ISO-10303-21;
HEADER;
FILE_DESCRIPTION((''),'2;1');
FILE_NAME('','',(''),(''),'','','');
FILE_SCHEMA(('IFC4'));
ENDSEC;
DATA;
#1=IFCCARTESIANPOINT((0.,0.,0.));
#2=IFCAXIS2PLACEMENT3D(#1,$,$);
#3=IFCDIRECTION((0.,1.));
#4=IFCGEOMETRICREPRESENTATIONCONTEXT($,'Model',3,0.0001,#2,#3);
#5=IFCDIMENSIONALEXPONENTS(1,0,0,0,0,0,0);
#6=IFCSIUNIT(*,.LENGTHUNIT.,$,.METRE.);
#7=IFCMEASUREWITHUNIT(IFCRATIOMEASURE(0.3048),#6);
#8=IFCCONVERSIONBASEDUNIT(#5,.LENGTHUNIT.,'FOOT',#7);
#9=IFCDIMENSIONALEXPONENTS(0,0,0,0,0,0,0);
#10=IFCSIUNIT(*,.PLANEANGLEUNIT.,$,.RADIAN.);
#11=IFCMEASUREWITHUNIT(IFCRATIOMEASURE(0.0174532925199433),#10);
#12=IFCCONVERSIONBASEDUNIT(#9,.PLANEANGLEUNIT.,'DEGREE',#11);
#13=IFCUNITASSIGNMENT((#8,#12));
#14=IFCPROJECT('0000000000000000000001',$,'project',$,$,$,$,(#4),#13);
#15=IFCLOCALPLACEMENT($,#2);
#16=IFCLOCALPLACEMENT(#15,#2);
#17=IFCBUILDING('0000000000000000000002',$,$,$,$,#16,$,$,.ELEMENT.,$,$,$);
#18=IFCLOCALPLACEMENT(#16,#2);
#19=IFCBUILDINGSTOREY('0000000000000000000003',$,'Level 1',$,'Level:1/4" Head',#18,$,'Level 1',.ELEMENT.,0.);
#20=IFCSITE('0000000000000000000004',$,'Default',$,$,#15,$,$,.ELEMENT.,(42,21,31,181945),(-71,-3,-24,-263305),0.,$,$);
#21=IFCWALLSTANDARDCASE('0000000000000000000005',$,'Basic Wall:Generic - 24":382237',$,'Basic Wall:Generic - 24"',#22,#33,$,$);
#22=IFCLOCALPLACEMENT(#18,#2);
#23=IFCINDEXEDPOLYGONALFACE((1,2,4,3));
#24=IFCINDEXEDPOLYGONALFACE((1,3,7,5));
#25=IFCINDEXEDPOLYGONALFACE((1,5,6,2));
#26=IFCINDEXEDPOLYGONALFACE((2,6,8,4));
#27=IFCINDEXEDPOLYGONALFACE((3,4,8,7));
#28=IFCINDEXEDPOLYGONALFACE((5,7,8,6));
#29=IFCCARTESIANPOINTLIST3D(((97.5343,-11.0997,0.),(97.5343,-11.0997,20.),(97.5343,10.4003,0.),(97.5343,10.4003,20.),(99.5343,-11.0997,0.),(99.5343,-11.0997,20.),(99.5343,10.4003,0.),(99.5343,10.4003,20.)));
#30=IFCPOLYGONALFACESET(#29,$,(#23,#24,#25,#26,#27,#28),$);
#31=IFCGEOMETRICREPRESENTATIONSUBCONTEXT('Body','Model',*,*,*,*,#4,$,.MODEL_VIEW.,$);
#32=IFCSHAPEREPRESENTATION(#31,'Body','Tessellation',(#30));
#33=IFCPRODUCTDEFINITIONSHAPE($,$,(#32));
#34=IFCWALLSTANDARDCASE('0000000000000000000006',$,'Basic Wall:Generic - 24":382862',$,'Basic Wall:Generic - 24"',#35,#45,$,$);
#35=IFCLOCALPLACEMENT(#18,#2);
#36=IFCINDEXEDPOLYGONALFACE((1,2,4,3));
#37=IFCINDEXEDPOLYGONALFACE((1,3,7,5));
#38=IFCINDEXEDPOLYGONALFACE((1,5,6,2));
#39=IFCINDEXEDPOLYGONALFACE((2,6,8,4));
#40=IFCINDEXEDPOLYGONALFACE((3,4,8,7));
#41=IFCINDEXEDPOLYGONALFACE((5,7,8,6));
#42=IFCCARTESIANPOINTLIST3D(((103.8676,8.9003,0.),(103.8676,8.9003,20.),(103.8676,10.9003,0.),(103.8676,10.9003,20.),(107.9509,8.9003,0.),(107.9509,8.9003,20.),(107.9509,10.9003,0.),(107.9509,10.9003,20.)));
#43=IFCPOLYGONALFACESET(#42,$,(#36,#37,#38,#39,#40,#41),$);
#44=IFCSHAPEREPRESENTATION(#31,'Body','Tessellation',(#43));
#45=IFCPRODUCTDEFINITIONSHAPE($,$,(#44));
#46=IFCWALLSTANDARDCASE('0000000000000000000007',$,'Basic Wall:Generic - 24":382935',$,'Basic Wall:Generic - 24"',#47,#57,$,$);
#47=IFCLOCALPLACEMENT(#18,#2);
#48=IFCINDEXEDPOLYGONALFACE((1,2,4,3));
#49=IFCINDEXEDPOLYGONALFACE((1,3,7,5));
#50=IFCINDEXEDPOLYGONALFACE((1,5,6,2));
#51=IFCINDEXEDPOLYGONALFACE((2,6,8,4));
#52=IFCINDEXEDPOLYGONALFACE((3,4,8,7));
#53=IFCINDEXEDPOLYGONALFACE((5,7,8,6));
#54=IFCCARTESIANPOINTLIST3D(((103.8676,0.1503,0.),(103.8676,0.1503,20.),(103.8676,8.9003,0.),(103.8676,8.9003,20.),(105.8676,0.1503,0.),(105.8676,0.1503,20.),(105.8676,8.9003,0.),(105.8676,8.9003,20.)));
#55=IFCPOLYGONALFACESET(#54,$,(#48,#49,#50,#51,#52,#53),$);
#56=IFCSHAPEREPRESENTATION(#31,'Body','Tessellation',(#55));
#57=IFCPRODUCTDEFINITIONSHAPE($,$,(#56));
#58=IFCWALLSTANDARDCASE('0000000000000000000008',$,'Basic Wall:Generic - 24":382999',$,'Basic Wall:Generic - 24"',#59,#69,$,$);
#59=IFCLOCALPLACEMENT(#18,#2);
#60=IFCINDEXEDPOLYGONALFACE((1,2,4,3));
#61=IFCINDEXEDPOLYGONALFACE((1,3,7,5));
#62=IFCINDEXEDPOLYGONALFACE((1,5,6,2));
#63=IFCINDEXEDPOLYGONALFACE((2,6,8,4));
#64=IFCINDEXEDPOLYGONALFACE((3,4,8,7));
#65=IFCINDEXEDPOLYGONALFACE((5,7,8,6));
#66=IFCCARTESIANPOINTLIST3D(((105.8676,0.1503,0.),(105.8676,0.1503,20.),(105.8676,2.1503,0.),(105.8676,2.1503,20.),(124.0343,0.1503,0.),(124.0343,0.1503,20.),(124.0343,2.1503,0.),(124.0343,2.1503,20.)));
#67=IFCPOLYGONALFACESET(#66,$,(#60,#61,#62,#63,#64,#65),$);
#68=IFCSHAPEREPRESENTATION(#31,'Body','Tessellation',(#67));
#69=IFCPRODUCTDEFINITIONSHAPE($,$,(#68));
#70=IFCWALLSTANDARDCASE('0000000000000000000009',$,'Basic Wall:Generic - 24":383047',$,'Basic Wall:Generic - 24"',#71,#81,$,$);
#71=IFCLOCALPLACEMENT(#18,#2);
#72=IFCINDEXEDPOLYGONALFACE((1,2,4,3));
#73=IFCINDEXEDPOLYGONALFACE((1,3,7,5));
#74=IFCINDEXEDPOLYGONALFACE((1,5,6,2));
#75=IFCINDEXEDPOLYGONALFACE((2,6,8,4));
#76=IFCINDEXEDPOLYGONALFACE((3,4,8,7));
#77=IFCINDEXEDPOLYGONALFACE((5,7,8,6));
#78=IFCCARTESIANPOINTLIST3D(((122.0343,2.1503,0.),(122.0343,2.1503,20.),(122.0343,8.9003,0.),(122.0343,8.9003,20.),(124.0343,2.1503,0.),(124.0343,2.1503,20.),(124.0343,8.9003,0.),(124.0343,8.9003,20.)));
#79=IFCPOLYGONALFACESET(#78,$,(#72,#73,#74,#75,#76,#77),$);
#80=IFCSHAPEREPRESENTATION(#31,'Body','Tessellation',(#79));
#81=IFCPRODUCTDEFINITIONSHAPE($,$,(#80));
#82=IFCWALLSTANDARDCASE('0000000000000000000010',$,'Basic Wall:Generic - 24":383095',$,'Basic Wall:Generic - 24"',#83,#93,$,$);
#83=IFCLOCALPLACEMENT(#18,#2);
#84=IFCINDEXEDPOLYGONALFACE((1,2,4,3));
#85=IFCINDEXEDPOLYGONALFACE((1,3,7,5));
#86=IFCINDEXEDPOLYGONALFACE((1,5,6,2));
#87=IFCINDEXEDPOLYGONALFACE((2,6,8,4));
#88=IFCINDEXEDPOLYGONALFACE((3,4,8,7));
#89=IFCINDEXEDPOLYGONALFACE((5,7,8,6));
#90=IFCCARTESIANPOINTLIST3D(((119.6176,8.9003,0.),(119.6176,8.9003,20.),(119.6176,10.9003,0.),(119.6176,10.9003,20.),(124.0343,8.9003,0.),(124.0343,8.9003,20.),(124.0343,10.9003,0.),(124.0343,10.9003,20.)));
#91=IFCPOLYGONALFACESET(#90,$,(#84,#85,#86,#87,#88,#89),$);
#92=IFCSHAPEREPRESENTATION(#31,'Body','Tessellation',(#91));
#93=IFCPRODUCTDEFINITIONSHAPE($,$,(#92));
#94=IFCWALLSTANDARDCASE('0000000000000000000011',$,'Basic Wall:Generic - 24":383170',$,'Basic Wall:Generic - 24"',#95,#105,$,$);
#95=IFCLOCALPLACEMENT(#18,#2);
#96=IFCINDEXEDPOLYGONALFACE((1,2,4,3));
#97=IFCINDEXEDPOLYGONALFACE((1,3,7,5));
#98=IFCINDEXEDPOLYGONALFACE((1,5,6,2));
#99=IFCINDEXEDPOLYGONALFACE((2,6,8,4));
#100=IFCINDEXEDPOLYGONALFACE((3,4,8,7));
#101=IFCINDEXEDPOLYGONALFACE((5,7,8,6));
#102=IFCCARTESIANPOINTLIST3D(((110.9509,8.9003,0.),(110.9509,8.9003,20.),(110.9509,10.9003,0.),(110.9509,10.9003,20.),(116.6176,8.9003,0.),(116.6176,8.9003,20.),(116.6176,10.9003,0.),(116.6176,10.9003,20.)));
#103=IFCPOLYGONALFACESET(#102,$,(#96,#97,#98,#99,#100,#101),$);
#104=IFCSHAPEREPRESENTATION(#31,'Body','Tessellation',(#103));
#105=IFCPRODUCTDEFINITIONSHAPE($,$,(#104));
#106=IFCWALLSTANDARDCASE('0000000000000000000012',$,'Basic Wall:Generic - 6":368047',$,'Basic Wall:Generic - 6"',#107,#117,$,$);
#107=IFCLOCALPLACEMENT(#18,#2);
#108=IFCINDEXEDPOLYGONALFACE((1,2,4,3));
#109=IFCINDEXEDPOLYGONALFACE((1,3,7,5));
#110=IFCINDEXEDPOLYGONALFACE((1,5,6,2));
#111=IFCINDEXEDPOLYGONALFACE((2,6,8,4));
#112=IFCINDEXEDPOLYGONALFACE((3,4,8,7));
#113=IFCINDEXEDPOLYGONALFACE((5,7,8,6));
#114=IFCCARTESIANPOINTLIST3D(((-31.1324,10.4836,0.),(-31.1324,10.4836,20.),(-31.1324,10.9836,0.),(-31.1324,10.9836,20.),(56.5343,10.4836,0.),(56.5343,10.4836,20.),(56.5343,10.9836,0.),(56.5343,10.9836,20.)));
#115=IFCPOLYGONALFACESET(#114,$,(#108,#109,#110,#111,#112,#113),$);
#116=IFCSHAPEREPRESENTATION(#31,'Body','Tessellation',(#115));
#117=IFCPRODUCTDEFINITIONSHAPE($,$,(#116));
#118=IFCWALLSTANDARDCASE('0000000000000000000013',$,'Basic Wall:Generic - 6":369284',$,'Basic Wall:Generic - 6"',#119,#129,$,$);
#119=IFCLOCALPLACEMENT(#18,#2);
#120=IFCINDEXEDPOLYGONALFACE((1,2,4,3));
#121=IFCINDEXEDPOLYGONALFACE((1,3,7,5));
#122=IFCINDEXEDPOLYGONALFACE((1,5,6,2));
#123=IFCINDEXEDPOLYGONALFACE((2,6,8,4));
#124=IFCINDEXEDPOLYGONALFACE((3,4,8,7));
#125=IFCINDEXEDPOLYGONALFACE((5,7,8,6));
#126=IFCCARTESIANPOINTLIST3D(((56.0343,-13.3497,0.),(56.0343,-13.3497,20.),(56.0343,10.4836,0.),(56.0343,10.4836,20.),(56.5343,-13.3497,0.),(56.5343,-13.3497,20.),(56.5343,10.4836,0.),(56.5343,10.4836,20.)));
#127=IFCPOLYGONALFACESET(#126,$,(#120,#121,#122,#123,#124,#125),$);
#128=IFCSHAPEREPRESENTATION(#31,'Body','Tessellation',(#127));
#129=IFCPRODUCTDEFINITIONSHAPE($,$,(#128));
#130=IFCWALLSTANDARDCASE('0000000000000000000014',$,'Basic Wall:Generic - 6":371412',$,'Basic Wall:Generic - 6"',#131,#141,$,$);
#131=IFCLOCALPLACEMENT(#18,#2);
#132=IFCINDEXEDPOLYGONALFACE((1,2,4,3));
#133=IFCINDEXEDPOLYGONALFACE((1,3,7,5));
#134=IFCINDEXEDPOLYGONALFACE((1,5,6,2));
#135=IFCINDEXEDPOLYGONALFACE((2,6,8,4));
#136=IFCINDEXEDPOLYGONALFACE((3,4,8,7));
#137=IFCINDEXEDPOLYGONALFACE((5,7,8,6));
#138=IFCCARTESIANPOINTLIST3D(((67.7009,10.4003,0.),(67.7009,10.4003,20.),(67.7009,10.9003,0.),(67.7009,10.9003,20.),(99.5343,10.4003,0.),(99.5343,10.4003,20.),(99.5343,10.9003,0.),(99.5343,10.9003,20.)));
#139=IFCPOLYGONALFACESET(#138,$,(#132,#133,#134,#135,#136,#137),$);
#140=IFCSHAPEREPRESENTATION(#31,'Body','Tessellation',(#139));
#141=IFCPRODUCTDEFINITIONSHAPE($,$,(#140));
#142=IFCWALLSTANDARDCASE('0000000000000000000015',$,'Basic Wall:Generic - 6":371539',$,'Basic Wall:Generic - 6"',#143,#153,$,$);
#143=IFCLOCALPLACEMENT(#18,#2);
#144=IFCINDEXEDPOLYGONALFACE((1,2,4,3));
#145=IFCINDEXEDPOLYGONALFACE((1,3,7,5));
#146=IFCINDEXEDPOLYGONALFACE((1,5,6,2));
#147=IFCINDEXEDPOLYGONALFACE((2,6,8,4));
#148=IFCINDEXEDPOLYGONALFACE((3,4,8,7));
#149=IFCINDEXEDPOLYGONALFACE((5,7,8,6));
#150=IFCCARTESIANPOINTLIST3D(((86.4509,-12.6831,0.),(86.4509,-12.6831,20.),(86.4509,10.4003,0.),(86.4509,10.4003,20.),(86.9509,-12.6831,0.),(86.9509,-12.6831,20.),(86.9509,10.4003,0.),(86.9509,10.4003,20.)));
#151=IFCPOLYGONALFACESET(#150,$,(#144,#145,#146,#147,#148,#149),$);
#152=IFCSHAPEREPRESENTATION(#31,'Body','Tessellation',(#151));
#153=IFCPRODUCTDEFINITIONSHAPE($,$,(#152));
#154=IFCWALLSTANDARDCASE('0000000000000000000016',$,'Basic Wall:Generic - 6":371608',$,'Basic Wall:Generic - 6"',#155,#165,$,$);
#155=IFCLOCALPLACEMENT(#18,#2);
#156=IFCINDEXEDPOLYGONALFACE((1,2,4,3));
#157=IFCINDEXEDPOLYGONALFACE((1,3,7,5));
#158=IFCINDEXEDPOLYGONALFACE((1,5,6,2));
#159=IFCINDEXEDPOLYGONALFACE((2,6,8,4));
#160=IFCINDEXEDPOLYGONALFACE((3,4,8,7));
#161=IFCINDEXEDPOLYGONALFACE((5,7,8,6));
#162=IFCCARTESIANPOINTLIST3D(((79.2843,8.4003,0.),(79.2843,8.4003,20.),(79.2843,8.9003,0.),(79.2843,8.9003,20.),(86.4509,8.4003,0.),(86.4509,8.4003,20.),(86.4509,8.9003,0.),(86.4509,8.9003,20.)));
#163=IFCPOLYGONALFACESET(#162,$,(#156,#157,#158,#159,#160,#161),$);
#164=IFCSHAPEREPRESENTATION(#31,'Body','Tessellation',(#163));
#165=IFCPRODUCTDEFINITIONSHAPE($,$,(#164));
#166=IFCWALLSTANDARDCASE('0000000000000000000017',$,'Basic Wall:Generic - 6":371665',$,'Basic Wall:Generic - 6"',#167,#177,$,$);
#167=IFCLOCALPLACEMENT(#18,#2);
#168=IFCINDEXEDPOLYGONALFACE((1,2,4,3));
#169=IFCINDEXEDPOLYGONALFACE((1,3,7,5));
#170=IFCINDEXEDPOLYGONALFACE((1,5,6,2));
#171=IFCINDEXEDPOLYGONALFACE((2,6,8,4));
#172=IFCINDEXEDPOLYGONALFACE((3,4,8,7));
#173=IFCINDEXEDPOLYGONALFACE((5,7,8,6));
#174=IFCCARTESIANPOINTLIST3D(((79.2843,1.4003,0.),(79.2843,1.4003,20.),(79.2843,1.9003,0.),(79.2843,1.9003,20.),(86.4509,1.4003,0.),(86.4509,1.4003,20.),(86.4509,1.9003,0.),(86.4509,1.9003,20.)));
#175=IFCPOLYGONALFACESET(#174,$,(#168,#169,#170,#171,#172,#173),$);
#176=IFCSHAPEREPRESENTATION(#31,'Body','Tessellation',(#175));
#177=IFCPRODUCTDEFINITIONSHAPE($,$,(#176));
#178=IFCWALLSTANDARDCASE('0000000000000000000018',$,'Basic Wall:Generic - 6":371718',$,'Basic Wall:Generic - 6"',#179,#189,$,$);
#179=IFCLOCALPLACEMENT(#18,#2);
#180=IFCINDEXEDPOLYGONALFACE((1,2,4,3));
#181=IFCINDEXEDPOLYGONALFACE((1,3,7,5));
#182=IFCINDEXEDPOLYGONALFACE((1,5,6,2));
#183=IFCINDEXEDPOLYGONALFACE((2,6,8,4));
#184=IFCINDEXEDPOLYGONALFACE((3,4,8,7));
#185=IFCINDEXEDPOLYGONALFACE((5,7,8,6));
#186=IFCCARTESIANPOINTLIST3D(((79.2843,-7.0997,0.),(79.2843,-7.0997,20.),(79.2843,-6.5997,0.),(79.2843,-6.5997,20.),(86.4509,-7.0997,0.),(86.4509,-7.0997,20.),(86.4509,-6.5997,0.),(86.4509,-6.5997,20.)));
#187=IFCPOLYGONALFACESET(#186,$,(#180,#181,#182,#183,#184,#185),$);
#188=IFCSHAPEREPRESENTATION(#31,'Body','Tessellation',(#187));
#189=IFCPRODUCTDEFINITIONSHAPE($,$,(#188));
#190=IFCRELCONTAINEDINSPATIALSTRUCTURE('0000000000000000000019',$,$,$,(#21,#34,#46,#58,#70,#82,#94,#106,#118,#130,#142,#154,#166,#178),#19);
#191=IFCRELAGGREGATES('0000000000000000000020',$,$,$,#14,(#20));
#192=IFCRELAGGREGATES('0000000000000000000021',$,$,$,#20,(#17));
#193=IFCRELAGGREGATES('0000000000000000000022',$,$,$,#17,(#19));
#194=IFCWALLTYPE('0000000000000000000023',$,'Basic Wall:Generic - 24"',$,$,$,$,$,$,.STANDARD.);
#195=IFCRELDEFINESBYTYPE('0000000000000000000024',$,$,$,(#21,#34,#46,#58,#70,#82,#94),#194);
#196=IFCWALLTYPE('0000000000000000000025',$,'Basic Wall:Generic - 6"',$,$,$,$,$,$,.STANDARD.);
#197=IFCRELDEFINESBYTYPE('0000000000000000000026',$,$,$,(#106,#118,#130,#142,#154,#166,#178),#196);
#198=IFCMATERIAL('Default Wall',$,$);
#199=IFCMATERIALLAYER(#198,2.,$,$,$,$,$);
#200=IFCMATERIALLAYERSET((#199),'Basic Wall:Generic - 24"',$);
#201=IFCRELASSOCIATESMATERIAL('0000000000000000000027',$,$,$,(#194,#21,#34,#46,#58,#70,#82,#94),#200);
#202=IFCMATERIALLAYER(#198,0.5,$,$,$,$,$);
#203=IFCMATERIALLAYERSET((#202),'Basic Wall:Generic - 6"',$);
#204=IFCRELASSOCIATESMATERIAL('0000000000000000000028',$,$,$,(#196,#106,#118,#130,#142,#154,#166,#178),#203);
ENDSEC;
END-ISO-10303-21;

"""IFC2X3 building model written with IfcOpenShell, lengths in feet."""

from ifc_helpers import new_model, entity, si_unit, converted_unit, direction, frame, frame_2d, origin, place, context, subcontext, project, spatial, rectangle, extrude, material, layer, layer_set, layer_usage, type_object, element, save


model = new_model("IFC2X3")

# Units and contexts
model_context = context("Model", 3, precision=0.0001, world=origin(), true_north=direction((0.0, 1.0)))
body_context = subcontext(model_context, "Body", "Model", "MODEL_VIEW")
ifc_project = project(units=[converted_unit("LENGTHUNIT", "FOOT", entity("IfcRatioMeasure", 0.3048), si_unit("LENGTHUNIT", "METRE"), dimensions=[1, 0, 0, 0, 0, 0, 0]), converted_unit("PLANEANGLEUNIT", "DEGREE", entity("IfcRatioMeasure", 0.0174532925199433), si_unit("PLANEANGLEUNIT", "RADIAN"), dimensions=[0, 0, 0, 0, 0, 0, 0])], contexts=[model_context])

# Site, building, storey
site_placement = place(None, origin())
site = spatial("IfcSite", under=ifc_project, at=site_placement, Name="Default", CompositionType="ELEMENT", RefLatitude=(42, 21, 31, 181945), RefLongitude=(-71, -3, -24, -263305), RefElevation=0.0)
building_placement = place(site_placement, origin())
building = spatial("IfcBuilding", under=site, at=building_placement, CompositionType="ELEMENT")
storey_placement = place(building_placement, origin())
storey = spatial("IfcBuildingStorey", under=building, at=storey_placement, Name="Level 1", ObjectType="Level:1/4\" Head", LongName="Level 1", CompositionType="ELEMENT", Elevation=0.0)

# Walls
ifc_material = material(Name="Default Wall")
ifc_layer_1 = layer(ifc_material, 2.0)
ifc_layer_set_1 = layer_set([ifc_layer_1], Name="Basic Wall:Generic - 24\"")
ifc_layer_usage_1 = layer_usage(ifc_layer_set_1, "AXIS2", "NEGATIVE", 1.0)
wall_type_1 = type_object("IfcWallType", Name="Basic Wall:Generic - 24\"", PredefinedType="STANDARD", material=ifc_layer_set_1)
wall_1_placement = place(storey_placement, frame((98.5343, 10.4003, 0.0), z_axis=(0.0, 0.0, 1.0), x_axis=(0.0, -1.0, 0.0)))
element("IfcWallStandardCase", 1, at=wall_1_placement, inside=storey, type_object=wall_type_1, material=ifc_layer_usage_1, Name="Basic Wall:Generic - 24\":382237", ObjectType="Basic Wall:Generic - 24\"", context=body_context, shape_type="SweptSolid", body=[
    extrude(rectangle(XDim=21.5, YDim=2.0, at=frame_2d((10.75, 0.0), x_axis=(-1.0, 0.0))), origin(), (0.0, 0.0, 1.0), 20.0),
])
ifc_layer_usage_2 = layer_usage(ifc_layer_set_1, "AXIS2", "NEGATIVE", 1.0)
wall_2_placement = place(storey_placement, frame((107.9509, 9.9003, 0.0), z_axis=(0.0, 0.0, 1.0), x_axis=(-1.0, 0.0, 0.0)))
element("IfcWallStandardCase", 2, at=wall_2_placement, inside=storey, type_object=wall_type_1, material=ifc_layer_usage_2, Name="Basic Wall:Generic - 24\":382862", ObjectType="Basic Wall:Generic - 24\"", context=body_context, shape_type="SweptSolid", body=[
    extrude(rectangle(XDim=4.0833, YDim=2.0, at=frame_2d((2.0417, 0.0), x_axis=(-1.0, 0.0))), origin(), (0.0, 0.0, 1.0), 20.0),
])
ifc_layer_usage_3 = layer_usage(ifc_layer_set_1, "AXIS2", "NEGATIVE", 1.0)
wall_3_placement = place(storey_placement, frame((104.8676, 8.9003, 0.0), z_axis=(0.0, 0.0, 1.0), x_axis=(0.0, -1.0, 0.0)))
element("IfcWallStandardCase", 3, at=wall_3_placement, inside=storey, type_object=wall_type_1, material=ifc_layer_usage_3, Name="Basic Wall:Generic - 24\":382935", ObjectType="Basic Wall:Generic - 24\"", context=body_context, shape_type="SweptSolid", body=[
    extrude(rectangle(XDim=8.75, YDim=2.0, at=frame_2d((4.375, 0.0), x_axis=(-1.0, 0.0))), origin(), (0.0, 0.0, 1.0), 20.0),
])
ifc_layer_usage_4 = layer_usage(ifc_layer_set_1, "AXIS2", "NEGATIVE", 1.0)
wall_4_placement = place(storey_placement, frame((105.8676, 1.1503, 0.0)))
element("IfcWallStandardCase", 4, at=wall_4_placement, inside=storey, type_object=wall_type_1, material=ifc_layer_usage_4, Name="Basic Wall:Generic - 24\":382999", ObjectType="Basic Wall:Generic - 24\"", context=body_context, shape_type="SweptSolid", body=[
    extrude(rectangle(XDim=18.1667, YDim=2.0, at=frame_2d((9.0833, 0.0), x_axis=(-1.0, 0.0))), origin(), (0.0, 0.0, 1.0), 20.0),
])
ifc_layer_usage_5 = layer_usage(ifc_layer_set_1, "AXIS2", "NEGATIVE", 1.0)
wall_5_placement = place(storey_placement, frame((123.0343, 2.1503, 0.0), z_axis=(0.0, 0.0, 1.0), x_axis=(0.0, 1.0, 0.0)))
element("IfcWallStandardCase", 5, at=wall_5_placement, inside=storey, type_object=wall_type_1, material=ifc_layer_usage_5, Name="Basic Wall:Generic - 24\":383047", ObjectType="Basic Wall:Generic - 24\"", context=body_context, shape_type="SweptSolid", body=[
    extrude(rectangle(XDim=6.75, YDim=2.0, at=frame_2d((3.375, 0.0), x_axis=(-1.0, 0.0))), origin(), (0.0, 0.0, 1.0), 20.0),
])
ifc_layer_usage_6 = layer_usage(ifc_layer_set_1, "AXIS2", "NEGATIVE", 1.0)
wall_6_placement = place(storey_placement, frame((124.0343, 9.9003, 0.0), z_axis=(0.0, 0.0, 1.0), x_axis=(-1.0, 0.0, 0.0)))
element("IfcWallStandardCase", 6, at=wall_6_placement, inside=storey, type_object=wall_type_1, material=ifc_layer_usage_6, Name="Basic Wall:Generic - 24\":383095", ObjectType="Basic Wall:Generic - 24\"", context=body_context, shape_type="SweptSolid", body=[
    extrude(rectangle(XDim=4.4167, YDim=2.0, at=frame_2d((2.2083, 0.0), x_axis=(-1.0, 0.0))), origin(), (0.0, 0.0, 1.0), 20.0),
])
ifc_layer_usage_7 = layer_usage(ifc_layer_set_1, "AXIS2", "NEGATIVE", 1.0)
wall_7_placement = place(storey_placement, frame((116.6176, 9.9003, 0.0), z_axis=(0.0, 0.0, 1.0), x_axis=(-1.0, 0.0, 0.0)))
element("IfcWallStandardCase", 7, at=wall_7_placement, inside=storey, type_object=wall_type_1, material=ifc_layer_usage_7, Name="Basic Wall:Generic - 24\":383170", ObjectType="Basic Wall:Generic - 24\"", context=body_context, shape_type="SweptSolid", body=[
    extrude(rectangle(XDim=5.6667, YDim=2.0, at=frame_2d((2.8333, 0.0), x_axis=(-1.0, 0.0))), origin(), (0.0, 0.0, 1.0), 20.0),
])
ifc_layer_2 = layer(ifc_material, 0.5)
ifc_layer_set_2 = layer_set([ifc_layer_2], Name="Basic Wall:Generic - 6\"")
ifc_layer_usage_8 = layer_usage(ifc_layer_set_2, "AXIS2", "NEGATIVE", 0.25)
wall_type_2 = type_object("IfcWallType", Name="Basic Wall:Generic - 6\"", PredefinedType="STANDARD", material=ifc_layer_set_2)
wall_8_placement = place(storey_placement, frame((56.5343, 10.7336, 0.0), z_axis=(0.0, 0.0, 1.0), x_axis=(-1.0, 0.0, 0.0)))
element("IfcWallStandardCase", 8, at=wall_8_placement, inside=storey, type_object=wall_type_2, material=ifc_layer_usage_8, Name="Basic Wall:Generic - 6\":368047", ObjectType="Basic Wall:Generic - 6\"", context=body_context, shape_type="SweptSolid", body=[
    extrude(rectangle(XDim=87.6667, YDim=0.5, at=frame_2d((43.8333, 0.0), x_axis=(-1.0, 0.0))), origin(), (0.0, 0.0, 1.0), 20.0),
])
ifc_layer_usage_9 = layer_usage(ifc_layer_set_2, "AXIS2", "NEGATIVE", 0.25)
wall_9_placement = place(storey_placement, frame((56.2843, 10.4836, 0.0), z_axis=(0.0, 0.0, 1.0), x_axis=(0.0, -1.0, 0.0)))
element("IfcWallStandardCase", 9, at=wall_9_placement, inside=storey, type_object=wall_type_2, material=ifc_layer_usage_9, Name="Basic Wall:Generic - 6\":369284", ObjectType="Basic Wall:Generic - 6\"", context=body_context, shape_type="SweptSolid", body=[
    extrude(rectangle(XDim=23.8333, YDim=0.5, at=frame_2d((11.9167, 0.0), x_axis=(-1.0, 0.0))), origin(), (0.0, 0.0, 1.0), 20.0),
])
ifc_layer_usage_10 = layer_usage(ifc_layer_set_2, "AXIS2", "NEGATIVE", 0.25)
wall_10_placement = place(storey_placement, frame((67.7009, 10.6503, 0.0)))
element("IfcWallStandardCase", 10, at=wall_10_placement, inside=storey, type_object=wall_type_2, material=ifc_layer_usage_10, Name="Basic Wall:Generic - 6\":371412", ObjectType="Basic Wall:Generic - 6\"", context=body_context, shape_type="SweptSolid", body=[
    extrude(rectangle(XDim=31.8333, YDim=0.5, at=frame_2d((15.9167, 0.0), x_axis=(-1.0, 0.0))), origin(), (0.0, 0.0, 1.0), 20.0),
])
ifc_layer_usage_11 = layer_usage(ifc_layer_set_2, "AXIS2", "NEGATIVE", 0.25)
wall_11_placement = place(storey_placement, frame((86.7009, 10.4003, 0.0), z_axis=(0.0, 0.0, 1.0), x_axis=(0.0, -1.0, 0.0)))
element("IfcWallStandardCase", 11, at=wall_11_placement, inside=storey, type_object=wall_type_2, material=ifc_layer_usage_11, Name="Basic Wall:Generic - 6\":371539", ObjectType="Basic Wall:Generic - 6\"", context=body_context, shape_type="SweptSolid", body=[
    extrude(rectangle(XDim=23.0833, YDim=0.5, at=frame_2d((11.5417, 0.0), x_axis=(-1.0, 0.0))), origin(), (0.0, 0.0, 1.0), 20.0),
])
ifc_layer_usage_12 = layer_usage(ifc_layer_set_2, "AXIS2", "NEGATIVE", 0.25)
wall_12_placement = place(storey_placement, frame((79.2843, 8.6503, 0.0)))
element("IfcWallStandardCase", 12, at=wall_12_placement, inside=storey, type_object=wall_type_2, material=ifc_layer_usage_12, Name="Basic Wall:Generic - 6\":371608", ObjectType="Basic Wall:Generic - 6\"", context=body_context, shape_type="SweptSolid", body=[
    extrude(rectangle(XDim=7.1667, YDim=0.5, at=frame_2d((3.5833, 0.0), x_axis=(-1.0, 0.0))), origin(), (0.0, 0.0, 1.0), 20.0),
])
ifc_layer_usage_13 = layer_usage(ifc_layer_set_2, "AXIS2", "NEGATIVE", 0.25)
wall_13_placement = place(storey_placement, frame((79.2843, 1.6503, 0.0)))
element("IfcWallStandardCase", 13, at=wall_13_placement, inside=storey, type_object=wall_type_2, material=ifc_layer_usage_13, Name="Basic Wall:Generic - 6\":371665", ObjectType="Basic Wall:Generic - 6\"", context=body_context, shape_type="SweptSolid", body=[
    extrude(rectangle(XDim=7.1667, YDim=0.5, at=frame_2d((3.5833, 0.0), x_axis=(-1.0, 0.0))), origin(), (0.0, 0.0, 1.0), 20.0),
])
ifc_layer_usage_14 = layer_usage(ifc_layer_set_2, "AXIS2", "NEGATIVE", 0.25)
wall_14_placement = place(storey_placement, frame((79.2843, -6.8497, 0.0)))
element("IfcWallStandardCase", 14, at=wall_14_placement, inside=storey, type_object=wall_type_2, material=ifc_layer_usage_14, Name="Basic Wall:Generic - 6\":371718", ObjectType="Basic Wall:Generic - 6\"", context=body_context, shape_type="SweptSolid", body=[
    extrude(rectangle(XDim=7.1667, YDim=0.5, at=frame_2d((3.5833, 0.0), x_axis=(-1.0, 0.0))), origin(), (0.0, 0.0, 1.0), 20.0),
])

save(model, "model.ifc")
